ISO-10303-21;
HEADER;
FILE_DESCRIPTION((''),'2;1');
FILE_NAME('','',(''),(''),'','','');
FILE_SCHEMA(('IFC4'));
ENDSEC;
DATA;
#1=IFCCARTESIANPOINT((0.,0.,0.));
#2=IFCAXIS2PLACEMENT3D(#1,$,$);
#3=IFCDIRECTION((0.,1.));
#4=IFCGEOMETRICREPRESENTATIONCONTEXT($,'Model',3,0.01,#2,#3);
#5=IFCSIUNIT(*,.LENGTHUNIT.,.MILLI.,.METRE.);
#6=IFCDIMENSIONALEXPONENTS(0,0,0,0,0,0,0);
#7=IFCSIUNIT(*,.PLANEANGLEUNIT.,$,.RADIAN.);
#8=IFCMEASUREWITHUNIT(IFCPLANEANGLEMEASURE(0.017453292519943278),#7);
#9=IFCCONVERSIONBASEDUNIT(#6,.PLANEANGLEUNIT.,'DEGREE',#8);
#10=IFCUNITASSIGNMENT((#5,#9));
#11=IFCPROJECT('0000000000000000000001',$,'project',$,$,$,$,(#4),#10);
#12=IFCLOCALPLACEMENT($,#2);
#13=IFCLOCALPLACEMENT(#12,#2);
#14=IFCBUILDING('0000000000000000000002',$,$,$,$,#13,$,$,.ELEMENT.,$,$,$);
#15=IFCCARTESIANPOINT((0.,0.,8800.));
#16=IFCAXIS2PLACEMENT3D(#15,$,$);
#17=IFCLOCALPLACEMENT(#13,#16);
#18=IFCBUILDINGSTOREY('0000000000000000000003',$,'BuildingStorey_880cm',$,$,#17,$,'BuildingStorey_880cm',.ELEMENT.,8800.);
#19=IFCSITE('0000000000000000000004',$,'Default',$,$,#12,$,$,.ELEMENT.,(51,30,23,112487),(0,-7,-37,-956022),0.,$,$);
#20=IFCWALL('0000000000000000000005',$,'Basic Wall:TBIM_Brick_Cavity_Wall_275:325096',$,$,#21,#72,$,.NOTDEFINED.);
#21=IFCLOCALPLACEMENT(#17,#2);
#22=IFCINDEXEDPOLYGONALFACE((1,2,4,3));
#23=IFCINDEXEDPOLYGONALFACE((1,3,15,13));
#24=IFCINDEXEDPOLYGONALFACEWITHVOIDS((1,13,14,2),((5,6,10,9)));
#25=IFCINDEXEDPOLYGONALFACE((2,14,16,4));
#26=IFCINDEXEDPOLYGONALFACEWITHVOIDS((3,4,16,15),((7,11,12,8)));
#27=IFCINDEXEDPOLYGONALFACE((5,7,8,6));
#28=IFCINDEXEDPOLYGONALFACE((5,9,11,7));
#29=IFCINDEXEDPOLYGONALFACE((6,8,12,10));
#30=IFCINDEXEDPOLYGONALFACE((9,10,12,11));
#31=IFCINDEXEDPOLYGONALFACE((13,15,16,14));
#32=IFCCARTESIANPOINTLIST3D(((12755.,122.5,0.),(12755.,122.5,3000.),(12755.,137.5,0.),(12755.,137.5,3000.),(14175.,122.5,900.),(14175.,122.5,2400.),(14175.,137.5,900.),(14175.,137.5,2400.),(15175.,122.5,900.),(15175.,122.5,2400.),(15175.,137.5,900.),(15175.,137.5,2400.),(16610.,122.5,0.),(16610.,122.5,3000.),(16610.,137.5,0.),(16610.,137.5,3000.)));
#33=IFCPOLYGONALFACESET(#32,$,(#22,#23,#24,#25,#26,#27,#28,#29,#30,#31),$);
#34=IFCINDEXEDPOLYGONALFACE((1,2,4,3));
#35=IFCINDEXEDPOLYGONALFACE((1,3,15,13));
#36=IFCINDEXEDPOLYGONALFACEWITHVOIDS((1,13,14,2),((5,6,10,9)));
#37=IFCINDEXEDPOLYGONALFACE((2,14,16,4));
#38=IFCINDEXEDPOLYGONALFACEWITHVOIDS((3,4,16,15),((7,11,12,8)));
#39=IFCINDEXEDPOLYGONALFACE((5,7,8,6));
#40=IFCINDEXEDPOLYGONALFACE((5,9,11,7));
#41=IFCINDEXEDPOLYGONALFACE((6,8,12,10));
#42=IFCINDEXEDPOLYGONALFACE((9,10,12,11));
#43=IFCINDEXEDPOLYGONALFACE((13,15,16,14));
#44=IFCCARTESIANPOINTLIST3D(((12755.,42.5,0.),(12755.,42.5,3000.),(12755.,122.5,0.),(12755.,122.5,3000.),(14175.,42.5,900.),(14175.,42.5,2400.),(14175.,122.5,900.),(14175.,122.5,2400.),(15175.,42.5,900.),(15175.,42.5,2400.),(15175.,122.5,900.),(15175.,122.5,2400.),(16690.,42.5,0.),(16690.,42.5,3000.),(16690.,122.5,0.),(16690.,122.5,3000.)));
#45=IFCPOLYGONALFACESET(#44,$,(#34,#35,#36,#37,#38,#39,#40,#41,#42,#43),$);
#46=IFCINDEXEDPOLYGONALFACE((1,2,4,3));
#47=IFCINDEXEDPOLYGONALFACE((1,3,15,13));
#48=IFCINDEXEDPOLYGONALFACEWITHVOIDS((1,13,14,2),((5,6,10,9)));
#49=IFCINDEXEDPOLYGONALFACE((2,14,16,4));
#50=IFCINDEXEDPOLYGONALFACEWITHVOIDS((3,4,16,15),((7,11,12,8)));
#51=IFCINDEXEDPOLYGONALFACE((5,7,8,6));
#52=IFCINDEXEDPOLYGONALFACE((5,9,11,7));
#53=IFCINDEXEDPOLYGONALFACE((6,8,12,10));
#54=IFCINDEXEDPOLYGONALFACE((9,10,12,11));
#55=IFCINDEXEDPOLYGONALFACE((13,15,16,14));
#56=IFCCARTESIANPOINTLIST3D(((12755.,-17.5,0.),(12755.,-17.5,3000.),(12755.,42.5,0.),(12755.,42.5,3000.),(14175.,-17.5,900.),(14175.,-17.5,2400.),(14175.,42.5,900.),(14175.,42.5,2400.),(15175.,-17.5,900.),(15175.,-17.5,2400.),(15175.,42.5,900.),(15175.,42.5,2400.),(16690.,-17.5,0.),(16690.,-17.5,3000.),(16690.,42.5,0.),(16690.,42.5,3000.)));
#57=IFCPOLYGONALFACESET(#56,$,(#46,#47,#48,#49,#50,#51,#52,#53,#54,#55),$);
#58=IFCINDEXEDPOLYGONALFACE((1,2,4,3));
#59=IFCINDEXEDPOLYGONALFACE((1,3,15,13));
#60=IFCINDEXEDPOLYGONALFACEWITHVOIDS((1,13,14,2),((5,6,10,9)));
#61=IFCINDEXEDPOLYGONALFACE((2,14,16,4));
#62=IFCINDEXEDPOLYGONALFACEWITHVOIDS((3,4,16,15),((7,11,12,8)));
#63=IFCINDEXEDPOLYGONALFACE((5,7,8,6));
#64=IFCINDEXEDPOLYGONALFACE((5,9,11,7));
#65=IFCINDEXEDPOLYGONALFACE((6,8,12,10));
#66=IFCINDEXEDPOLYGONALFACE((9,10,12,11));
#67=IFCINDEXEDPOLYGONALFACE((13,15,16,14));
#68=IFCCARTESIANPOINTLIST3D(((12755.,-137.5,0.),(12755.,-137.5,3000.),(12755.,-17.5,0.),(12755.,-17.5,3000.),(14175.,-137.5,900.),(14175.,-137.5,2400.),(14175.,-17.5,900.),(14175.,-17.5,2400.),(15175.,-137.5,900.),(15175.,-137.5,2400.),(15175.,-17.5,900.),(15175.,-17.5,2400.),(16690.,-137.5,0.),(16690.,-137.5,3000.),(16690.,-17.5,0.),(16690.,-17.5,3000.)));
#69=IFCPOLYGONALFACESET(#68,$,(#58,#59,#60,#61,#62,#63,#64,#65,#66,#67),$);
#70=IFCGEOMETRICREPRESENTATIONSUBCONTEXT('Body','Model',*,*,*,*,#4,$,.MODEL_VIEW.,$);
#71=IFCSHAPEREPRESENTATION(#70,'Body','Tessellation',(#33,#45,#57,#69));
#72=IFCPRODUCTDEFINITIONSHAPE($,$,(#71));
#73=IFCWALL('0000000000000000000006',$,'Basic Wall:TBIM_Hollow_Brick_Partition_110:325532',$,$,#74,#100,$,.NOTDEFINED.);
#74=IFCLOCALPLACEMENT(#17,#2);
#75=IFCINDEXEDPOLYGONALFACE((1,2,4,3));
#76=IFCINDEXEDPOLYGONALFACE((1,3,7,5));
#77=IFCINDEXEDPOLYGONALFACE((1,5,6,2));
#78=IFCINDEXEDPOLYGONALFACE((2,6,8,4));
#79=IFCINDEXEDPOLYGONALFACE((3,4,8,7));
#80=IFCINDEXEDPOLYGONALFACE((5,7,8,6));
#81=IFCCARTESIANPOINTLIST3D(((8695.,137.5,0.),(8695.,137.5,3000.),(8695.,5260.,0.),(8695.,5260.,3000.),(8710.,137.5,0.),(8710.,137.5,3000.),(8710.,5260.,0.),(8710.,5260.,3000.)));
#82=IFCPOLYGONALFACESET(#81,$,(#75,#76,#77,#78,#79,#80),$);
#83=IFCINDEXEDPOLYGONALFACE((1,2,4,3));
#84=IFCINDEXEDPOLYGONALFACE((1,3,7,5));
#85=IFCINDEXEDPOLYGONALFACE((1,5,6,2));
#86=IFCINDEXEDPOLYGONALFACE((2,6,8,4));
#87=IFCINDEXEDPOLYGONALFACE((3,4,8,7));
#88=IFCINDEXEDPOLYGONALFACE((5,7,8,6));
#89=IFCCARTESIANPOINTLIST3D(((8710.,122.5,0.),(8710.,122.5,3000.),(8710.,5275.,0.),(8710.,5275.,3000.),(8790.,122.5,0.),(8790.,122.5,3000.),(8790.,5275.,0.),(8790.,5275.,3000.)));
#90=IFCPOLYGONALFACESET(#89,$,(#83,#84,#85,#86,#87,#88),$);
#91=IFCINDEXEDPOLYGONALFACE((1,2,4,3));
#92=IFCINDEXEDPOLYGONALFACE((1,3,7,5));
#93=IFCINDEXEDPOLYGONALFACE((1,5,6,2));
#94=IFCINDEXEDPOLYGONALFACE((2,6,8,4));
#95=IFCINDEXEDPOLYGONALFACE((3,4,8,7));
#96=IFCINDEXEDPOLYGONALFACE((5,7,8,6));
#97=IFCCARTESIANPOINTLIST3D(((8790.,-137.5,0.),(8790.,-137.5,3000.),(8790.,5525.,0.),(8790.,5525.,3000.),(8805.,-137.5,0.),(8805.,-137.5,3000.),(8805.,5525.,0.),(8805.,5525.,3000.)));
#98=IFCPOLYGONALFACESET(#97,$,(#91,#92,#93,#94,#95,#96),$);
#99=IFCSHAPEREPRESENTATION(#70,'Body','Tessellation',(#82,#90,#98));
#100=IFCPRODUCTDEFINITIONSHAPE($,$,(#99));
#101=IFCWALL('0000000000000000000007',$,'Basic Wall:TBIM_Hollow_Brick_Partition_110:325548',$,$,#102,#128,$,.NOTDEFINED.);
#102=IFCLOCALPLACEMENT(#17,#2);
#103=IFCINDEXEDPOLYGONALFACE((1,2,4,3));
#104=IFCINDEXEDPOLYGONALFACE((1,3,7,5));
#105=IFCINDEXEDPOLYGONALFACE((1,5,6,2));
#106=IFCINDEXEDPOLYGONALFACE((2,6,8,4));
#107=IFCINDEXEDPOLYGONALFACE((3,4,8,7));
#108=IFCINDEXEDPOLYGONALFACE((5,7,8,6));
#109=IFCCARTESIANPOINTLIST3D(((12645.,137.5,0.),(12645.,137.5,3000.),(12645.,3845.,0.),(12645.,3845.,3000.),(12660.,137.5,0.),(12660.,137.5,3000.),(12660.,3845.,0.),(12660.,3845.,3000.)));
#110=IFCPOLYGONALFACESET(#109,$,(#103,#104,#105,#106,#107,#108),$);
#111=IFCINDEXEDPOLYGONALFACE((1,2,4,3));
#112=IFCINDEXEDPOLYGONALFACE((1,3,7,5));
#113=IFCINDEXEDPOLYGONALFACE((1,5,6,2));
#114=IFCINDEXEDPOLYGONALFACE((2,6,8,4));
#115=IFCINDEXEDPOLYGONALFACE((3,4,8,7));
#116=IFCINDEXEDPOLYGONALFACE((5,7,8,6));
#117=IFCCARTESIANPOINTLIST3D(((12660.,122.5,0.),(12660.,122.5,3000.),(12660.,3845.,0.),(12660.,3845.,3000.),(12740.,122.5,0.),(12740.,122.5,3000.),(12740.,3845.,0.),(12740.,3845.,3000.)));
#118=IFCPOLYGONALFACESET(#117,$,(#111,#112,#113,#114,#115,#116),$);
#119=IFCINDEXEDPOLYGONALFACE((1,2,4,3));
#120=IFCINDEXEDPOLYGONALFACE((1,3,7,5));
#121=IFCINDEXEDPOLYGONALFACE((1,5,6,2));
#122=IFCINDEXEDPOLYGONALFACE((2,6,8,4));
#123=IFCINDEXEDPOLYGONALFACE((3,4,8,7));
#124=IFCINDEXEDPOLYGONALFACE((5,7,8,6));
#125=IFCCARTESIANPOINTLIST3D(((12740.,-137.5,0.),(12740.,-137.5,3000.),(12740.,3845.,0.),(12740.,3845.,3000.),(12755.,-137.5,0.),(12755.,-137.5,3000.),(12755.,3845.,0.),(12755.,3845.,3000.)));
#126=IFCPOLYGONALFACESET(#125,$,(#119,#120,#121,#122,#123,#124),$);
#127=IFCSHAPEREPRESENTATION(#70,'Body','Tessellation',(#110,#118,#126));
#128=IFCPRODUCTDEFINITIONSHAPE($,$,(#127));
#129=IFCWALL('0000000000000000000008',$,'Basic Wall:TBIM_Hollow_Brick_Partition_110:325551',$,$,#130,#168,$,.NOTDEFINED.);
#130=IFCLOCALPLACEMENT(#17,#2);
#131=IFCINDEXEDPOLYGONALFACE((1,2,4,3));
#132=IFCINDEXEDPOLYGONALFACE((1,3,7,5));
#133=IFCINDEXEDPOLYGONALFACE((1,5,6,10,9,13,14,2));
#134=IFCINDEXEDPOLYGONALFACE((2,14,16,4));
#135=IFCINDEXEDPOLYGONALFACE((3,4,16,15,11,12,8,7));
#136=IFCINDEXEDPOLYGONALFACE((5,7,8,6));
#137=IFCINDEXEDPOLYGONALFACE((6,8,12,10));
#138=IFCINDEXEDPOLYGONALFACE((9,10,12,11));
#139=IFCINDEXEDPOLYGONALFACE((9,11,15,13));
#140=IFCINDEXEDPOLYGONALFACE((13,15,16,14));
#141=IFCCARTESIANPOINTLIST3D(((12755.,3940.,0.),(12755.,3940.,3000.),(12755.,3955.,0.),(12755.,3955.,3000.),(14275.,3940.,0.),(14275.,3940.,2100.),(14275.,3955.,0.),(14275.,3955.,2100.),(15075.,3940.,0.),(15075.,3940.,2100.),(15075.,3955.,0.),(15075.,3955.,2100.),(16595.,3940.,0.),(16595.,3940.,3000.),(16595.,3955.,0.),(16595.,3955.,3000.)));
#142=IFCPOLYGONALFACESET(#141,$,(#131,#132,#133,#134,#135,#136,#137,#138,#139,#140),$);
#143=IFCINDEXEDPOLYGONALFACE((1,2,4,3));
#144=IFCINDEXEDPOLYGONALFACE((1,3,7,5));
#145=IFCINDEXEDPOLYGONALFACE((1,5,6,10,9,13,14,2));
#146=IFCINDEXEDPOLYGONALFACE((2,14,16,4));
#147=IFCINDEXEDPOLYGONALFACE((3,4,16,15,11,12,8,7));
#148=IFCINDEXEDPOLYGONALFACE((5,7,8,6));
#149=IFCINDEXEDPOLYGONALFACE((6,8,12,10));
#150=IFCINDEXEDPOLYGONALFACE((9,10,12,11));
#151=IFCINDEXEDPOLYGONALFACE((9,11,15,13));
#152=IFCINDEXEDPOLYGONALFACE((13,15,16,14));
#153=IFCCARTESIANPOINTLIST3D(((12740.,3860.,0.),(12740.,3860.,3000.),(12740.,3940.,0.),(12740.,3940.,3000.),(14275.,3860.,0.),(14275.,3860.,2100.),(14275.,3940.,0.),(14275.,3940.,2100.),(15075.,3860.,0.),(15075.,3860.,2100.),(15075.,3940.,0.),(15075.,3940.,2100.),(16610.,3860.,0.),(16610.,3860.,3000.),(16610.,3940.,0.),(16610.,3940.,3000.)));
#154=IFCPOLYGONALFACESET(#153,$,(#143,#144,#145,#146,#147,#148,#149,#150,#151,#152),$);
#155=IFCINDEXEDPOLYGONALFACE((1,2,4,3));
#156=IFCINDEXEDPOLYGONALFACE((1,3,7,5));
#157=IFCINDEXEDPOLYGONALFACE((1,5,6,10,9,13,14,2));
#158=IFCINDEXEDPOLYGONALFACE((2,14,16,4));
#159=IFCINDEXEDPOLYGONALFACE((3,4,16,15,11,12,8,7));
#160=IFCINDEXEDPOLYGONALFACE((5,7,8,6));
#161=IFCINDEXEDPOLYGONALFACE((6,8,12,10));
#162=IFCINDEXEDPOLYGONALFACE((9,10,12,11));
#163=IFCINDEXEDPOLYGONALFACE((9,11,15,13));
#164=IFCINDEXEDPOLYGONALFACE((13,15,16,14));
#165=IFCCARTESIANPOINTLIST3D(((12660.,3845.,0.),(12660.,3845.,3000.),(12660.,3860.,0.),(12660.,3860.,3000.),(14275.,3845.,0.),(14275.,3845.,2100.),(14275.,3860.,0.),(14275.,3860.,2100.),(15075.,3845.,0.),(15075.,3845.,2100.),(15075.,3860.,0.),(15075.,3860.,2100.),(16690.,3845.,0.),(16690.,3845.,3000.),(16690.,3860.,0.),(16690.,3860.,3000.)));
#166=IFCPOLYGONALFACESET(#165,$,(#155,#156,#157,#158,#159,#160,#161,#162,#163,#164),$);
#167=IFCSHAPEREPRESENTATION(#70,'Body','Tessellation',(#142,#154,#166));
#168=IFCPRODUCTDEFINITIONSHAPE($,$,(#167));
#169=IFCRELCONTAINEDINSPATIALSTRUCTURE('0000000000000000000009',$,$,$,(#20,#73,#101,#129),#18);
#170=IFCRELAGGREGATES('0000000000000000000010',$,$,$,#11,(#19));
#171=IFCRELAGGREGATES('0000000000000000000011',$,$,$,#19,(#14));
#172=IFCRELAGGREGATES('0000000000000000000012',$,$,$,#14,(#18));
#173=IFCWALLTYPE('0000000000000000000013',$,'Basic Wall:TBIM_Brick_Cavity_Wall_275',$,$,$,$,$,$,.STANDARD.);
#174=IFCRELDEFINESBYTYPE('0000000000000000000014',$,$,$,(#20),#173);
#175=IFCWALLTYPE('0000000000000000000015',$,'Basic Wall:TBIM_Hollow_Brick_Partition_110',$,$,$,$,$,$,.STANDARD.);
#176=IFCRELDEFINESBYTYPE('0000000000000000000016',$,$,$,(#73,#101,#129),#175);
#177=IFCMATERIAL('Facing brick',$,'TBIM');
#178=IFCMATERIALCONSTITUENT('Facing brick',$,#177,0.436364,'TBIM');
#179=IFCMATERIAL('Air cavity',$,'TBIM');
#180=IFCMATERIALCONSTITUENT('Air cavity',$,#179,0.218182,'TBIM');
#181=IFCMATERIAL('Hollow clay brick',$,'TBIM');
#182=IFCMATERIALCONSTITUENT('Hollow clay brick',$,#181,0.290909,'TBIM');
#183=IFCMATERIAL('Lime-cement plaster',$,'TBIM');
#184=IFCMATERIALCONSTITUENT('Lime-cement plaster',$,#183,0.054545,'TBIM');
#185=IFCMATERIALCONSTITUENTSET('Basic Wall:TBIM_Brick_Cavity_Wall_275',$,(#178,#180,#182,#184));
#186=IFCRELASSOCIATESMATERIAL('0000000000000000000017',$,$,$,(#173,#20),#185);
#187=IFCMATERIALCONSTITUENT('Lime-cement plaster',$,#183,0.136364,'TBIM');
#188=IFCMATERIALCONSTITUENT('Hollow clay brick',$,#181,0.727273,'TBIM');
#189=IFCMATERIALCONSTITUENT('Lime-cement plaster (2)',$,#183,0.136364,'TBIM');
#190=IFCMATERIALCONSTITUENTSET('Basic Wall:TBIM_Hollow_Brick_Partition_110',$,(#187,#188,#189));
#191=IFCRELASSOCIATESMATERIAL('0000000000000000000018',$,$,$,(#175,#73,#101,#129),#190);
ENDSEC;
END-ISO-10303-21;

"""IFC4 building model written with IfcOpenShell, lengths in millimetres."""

from ifc_helpers import new_model, entity, si_unit, converted_unit, direction, frame, origin, place, context, subcontext, project, spatial, indexed_curve, outline, extrude, material, constituent, constituent_set, type_object, element, save


model = new_model("IFC4")

# Units and contexts
model_context = context("Model", 3, precision=0.01, world=origin(), true_north=direction((0.0, 1.0)))
body_context = subcontext(model_context, "Body", "Model", "MODEL_VIEW")
ifc_project = project(units=[si_unit("LENGTHUNIT", "METRE", prefix="MILLI"), converted_unit("PLANEANGLEUNIT", "DEGREE", entity("IfcPlaneAngleMeasure", 0.017453292519943278), si_unit("PLANEANGLEUNIT", "RADIAN"), dimensions=[0, 0, 0, 0, 0, 0, 0])], contexts=[model_context])

# Site, building, storey
site_placement = place(None, origin())
site = spatial("IfcSite", under=ifc_project, at=site_placement, Name="Default", CompositionType="ELEMENT", RefLatitude=(51, 30, 23, 112487), RefLongitude=(0, -7, -37, -956022), RefElevation=0.0)
building_placement = place(site_placement, origin())
building = spatial("IfcBuilding", under=site, at=building_placement, CompositionType="ELEMENT")
storey_placement = place(building_placement, frame((0.0, 0.0, 8800.0)))
storey = spatial("IfcBuildingStorey", under=building, at=storey_placement, Name="BuildingStorey_880cm", LongName="BuildingStorey_880cm", CompositionType="ELEMENT", Elevation=8800.0)

# Wall, opening
ifc_material_1 = material(Name="Facing brick", Category="TBIM")
ifc_constituent_1 = constituent(ifc_material_1, Name="Facing brick", Category="TBIM", fraction=0.436364)
ifc_material_2 = material(Name="Air cavity", Category="TBIM")
ifc_constituent_2 = constituent(ifc_material_2, Name="Air cavity", Category="TBIM", fraction=0.218182)
ifc_material_3 = material(Name="Hollow clay brick", Category="TBIM")
ifc_constituent_3 = constituent(ifc_material_3, Name="Hollow clay brick", Category="TBIM", fraction=0.290909)
ifc_material_4 = material(Name="Lime-cement plaster", Category="TBIM")
ifc_constituent_4 = constituent(ifc_material_4, Name="Lime-cement plaster", Category="TBIM", fraction=0.054545)
ifc_constituent_set_1 = constituent_set(constituents=[ifc_constituent_1, ifc_constituent_2, ifc_constituent_3, ifc_constituent_4], Name="Basic Wall:TBIM_Brick_Cavity_Wall_275")
wall_type_1 = type_object("IfcWallType", Name="Basic Wall:TBIM_Brick_Cavity_Wall_275", PredefinedType="STANDARD", material=ifc_constituent_set_1)
wall_1_placement = place(storey_placement, frame((12755.0, 0.0, 0.0)))
wall_1 = element("IfcWall", 1, at=wall_1_placement, inside=storey, type_object=wall_type_1, material=ifc_constituent_set_1, Name="Basic Wall:TBIM_Brick_Cavity_Wall_275:325096", PredefinedType="NOTDEFINED", context=body_context, shape_type="SweptSolid", body=[
    extrude(outline(indexed_curve([(-1500.0, -1927.5), (1500.0, -1927.5), (1500.0, 1927.5), (-1500.0, 1927.5), (-1500.0, -1927.5)], self_intersect=False), holes=[indexed_curve([(-600.0, -507.5), (-600.0, 492.5), (900.0, 492.5), (900.0, -507.5), (-600.0, -507.5)], self_intersect=False)]), frame((1927.5, 122.5, 1500.0), z_axis=(0.0, 1.0, 0.0), x_axis=(0.0, 0.0, 1.0)), (0.0, 0.0, 1.0), 15.0),
    extrude(outline(indexed_curve([(-1500.0, -1967.5), (1500.0, -1967.5), (1500.0, 1967.5), (-1500.0, 1967.5), (-1500.0, -1967.5)], self_intersect=False), holes=[indexed_curve([(-600.0, -547.5), (-600.0, 452.5), (900.0, 452.5), (900.0, -547.5), (-600.0, -547.5)], self_intersect=False)]), frame((1967.5, 42.5, 1500.0), z_axis=(0.0, 1.0, 0.0), x_axis=(0.0, 0.0, 1.0)), (0.0, 0.0, 1.0), 80.0),
    extrude(outline(indexed_curve([(-1500.0, -1967.5), (1500.0, -1967.5), (1500.0, 1967.5), (-1500.0, 1967.5), (-1500.0, -1967.5)], self_intersect=False), holes=[indexed_curve([(-600.0, -547.5), (-600.0, 452.5), (900.0, 452.5), (900.0, -547.5), (-600.0, -547.5)], self_intersect=False)]), frame((1967.5, -17.5, 1500.0), z_axis=(0.0, 1.0, 0.0), x_axis=(0.0, 0.0, 1.0)), (0.0, 0.0, 1.0), 60.0),
    extrude(outline(indexed_curve([(-1500.0, -1967.5), (1500.0, -1967.5), (1500.0, 1967.5), (-1500.0, 1967.5), (-1500.0, -1967.5)], self_intersect=False), holes=[indexed_curve([(900.0, -547.5), (-600.0, -547.5), (-600.0, 452.5), (900.0, 452.5), (900.0, -547.5)], self_intersect=False)]), frame((1967.5, -137.5, 1500.0), z_axis=(0.0, 1.0, 0.0), x_axis=(0.0, 0.0, 1.0)), (0.0, 0.0, 1.0), 120.0),
])
opening_1_placement = place(wall_1_placement, frame((1420.0, -137.5, 900.0)))
element("IfcOpeningElement", 2, at=opening_1_placement, cuts=wall_1, PredefinedType="OPENING", context=body_context, shape_type="SweptSolid", body=[
    extrude(outline(indexed_curve([(1500.0, 0.0), (1500.0, 1000.0), (0.0, 1000.0), (0.0, 0.0), (1500.0, 0.0)], self_intersect=False)), frame((0.0, 0.0, 0.0), z_axis=(0.0, 1.0, 0.0), x_axis=(0.0, 0.0, 1.0)), (0.0, 0.0, 1.0), 275.0),
])
ifc_constituent_5 = constituent(ifc_material_4, Name="Lime-cement plaster", Category="TBIM", fraction=0.136364)
ifc_constituent_6 = constituent(ifc_material_3, Name="Hollow clay brick", Category="TBIM", fraction=0.727273)
ifc_constituent_7 = constituent(ifc_material_4, Name="Lime-cement plaster (2)", Category="TBIM", fraction=0.136364)
ifc_constituent_set_2 = constituent_set(constituents=[ifc_constituent_5, ifc_constituent_6, ifc_constituent_7], Name="Basic Wall:TBIM_Hollow_Brick_Partition_110")
wall_type_2 = type_object("IfcWallType", Name="Basic Wall:TBIM_Hollow_Brick_Partition_110", PredefinedType="STANDARD", material=ifc_constituent_set_2)

# Wall
wall_2_placement = place(storey_placement, frame((8750.0, 137.5, 0.0), z_axis=(0.0, 0.0, 1.0), x_axis=(0.0, 1.0, 0.0)))
element("IfcWall", 3, at=wall_2_placement, inside=storey, type_object=wall_type_2, material=ifc_constituent_set_2, Name="Basic Wall:TBIM_Hollow_Brick_Partition_110:325532", PredefinedType="NOTDEFINED", context=body_context, shape_type="SweptSolid", body=[
    extrude(outline(indexed_curve([(-7.5, -2561.3), (7.5, -2561.3), (7.5, 2561.3), (-7.5, 2561.3), (-7.5, -2561.3)], self_intersect=False)), frame((2561.3, 47.5, 0.0), z_axis=(0.0, 0.0, 1.0), x_axis=(0.0, -1.0, 0.0)), (0.0, 0.0, 1.0), 3000.0),
    extrude(outline(indexed_curve([(-2576.3, -40.0), (2576.3, -40.0), (2576.3, 40.0), (-2576.3, 40.0), (-2576.3, -40.0)], self_intersect=False)), frame((2561.3, 0.0, 0.0)), (0.0, 0.0, 1.0), 3000.0),
    extrude(outline(indexed_curve([(-7.5, -2831.3), (7.5, -2831.3), (7.5, 2831.3), (-7.5, 2831.3), (-7.5, -2831.3)], self_intersect=False)), frame((2556.3, -47.5, 0.0), z_axis=(0.0, 0.0, 1.0), x_axis=(0.0, 1.0, 0.0)), (0.0, 0.0, 1.0), 3000.0),
])

# Wall
wall_3_placement = place(storey_placement, frame((12700.0, 137.5, 0.0), z_axis=(0.0, 0.0, 1.0), x_axis=(0.0, 1.0, 0.0)))
element("IfcWall", 4, at=wall_3_placement, inside=storey, type_object=wall_type_2, material=ifc_constituent_set_2, Name="Basic Wall:TBIM_Hollow_Brick_Partition_110:325548", PredefinedType="NOTDEFINED", context=body_context, shape_type="SweptSolid", body=[
    extrude(outline(indexed_curve([(-7.5, -1853.8), (7.5, -1853.8), (7.5, 1853.8), (-7.5, 1853.8), (-7.5, -1853.8)], self_intersect=False)), frame((1853.8, 47.5, 0.0), z_axis=(0.0, 0.0, 1.0), x_axis=(0.0, -1.0, 0.0)), (0.0, 0.0, 1.0), 3000.0),
    extrude(outline(indexed_curve([(-1861.3, -40.0), (1861.3, -40.0), (1861.3, 40.0), (-1861.3, 40.0), (-1861.3, -40.0)], self_intersect=False)), frame((1846.3, 0.0, 0.0)), (0.0, 0.0, 1.0), 3000.0),
    extrude(outline(indexed_curve([(-7.5, -1991.3), (7.5, -1991.3), (7.5, 1991.3), (-7.5, 1991.3), (-7.5, -1991.3)], self_intersect=False)), frame((1716.3, -47.5, 0.0), z_axis=(0.0, 0.0, 1.0), x_axis=(0.0, 1.0, 0.0)), (0.0, 0.0, 1.0), 3000.0),
])

# Wall, opening
wall_4_placement = place(storey_placement, frame((12755.0, 3900.0, 0.0)))
wall_4 = element("IfcWall", 5, at=wall_4_placement, inside=storey, type_object=wall_type_2, material=ifc_constituent_set_2, Name="Basic Wall:TBIM_Hollow_Brick_Partition_110:325551", PredefinedType="NOTDEFINED", context=body_context, shape_type="SweptSolid", body=[
    extrude(outline(indexed_curve([(-1275.0, -1920.0), (1725.0, -1920.0), (1725.0, 1920.0), (-1275.0, 1920.0), (-1275.0, 400.0), (825.0, 400.0), (825.0, -400.0), (-1275.0, -400.0), (-1275.0, -1920.0)], self_intersect=False)), frame((1920.0, 40.0, 1275.0), z_axis=(0.0, 1.0, 0.0), x_axis=(0.0, 0.0, 1.0)), (0.0, 0.0, 1.0), 15.0),
    extrude(outline(indexed_curve([(-1275.0, -1935.0), (1725.0, -1935.0), (1725.0, 1935.0), (-1275.0, 1935.0), (-1275.0, 400.0), (825.0, 400.0), (825.0, -400.0), (-1275.0, -400.0), (-1275.0, -1935.0)], self_intersect=False)), frame((1920.0, -40.0, 1275.0), z_axis=(0.0, 1.0, 0.0), x_axis=(0.0, 0.0, 1.0)), (0.0, 0.0, 1.0), 80.0),
    extrude(outline(indexed_curve([(-1725.0, -2015.0), (1275.0, -2015.0), (1275.0, -400.0), (-825.0, -400.0), (-825.0, 400.0), (1275.0, 400.0), (1275.0, 2015.0), (-1725.0, 2015.0), (-1725.0, -2015.0)], self_intersect=False)), frame((1920.0, -55.0, 1275.0), z_axis=(0.0, 1.0, 0.0), x_axis=(0.0, 0.0, -1.0)), (0.0, 0.0, 1.0), 15.0),
])
opening_2_placement = place(wall_4_placement, frame((1520.0, -55.0, 0.0)))
element("IfcOpeningElement", 6, at=opening_2_placement, cuts=wall_4, PredefinedType="OPENING", context=body_context, shape_type="SweptSolid", body=[
    extrude(outline(indexed_curve([(0.0, 800.0), (0.0, 0.0), (2100.0, 0.0), (2100.0, 800.0), (0.0, 800.0)], self_intersect=False)), frame((0.0, 0.0, 0.0), z_axis=(0.0, 1.0, 0.0), x_axis=(0.0, 0.0, 1.0)), (0.0, 0.0, 1.0), 110.0),
])

save(model, "model.ifc")
